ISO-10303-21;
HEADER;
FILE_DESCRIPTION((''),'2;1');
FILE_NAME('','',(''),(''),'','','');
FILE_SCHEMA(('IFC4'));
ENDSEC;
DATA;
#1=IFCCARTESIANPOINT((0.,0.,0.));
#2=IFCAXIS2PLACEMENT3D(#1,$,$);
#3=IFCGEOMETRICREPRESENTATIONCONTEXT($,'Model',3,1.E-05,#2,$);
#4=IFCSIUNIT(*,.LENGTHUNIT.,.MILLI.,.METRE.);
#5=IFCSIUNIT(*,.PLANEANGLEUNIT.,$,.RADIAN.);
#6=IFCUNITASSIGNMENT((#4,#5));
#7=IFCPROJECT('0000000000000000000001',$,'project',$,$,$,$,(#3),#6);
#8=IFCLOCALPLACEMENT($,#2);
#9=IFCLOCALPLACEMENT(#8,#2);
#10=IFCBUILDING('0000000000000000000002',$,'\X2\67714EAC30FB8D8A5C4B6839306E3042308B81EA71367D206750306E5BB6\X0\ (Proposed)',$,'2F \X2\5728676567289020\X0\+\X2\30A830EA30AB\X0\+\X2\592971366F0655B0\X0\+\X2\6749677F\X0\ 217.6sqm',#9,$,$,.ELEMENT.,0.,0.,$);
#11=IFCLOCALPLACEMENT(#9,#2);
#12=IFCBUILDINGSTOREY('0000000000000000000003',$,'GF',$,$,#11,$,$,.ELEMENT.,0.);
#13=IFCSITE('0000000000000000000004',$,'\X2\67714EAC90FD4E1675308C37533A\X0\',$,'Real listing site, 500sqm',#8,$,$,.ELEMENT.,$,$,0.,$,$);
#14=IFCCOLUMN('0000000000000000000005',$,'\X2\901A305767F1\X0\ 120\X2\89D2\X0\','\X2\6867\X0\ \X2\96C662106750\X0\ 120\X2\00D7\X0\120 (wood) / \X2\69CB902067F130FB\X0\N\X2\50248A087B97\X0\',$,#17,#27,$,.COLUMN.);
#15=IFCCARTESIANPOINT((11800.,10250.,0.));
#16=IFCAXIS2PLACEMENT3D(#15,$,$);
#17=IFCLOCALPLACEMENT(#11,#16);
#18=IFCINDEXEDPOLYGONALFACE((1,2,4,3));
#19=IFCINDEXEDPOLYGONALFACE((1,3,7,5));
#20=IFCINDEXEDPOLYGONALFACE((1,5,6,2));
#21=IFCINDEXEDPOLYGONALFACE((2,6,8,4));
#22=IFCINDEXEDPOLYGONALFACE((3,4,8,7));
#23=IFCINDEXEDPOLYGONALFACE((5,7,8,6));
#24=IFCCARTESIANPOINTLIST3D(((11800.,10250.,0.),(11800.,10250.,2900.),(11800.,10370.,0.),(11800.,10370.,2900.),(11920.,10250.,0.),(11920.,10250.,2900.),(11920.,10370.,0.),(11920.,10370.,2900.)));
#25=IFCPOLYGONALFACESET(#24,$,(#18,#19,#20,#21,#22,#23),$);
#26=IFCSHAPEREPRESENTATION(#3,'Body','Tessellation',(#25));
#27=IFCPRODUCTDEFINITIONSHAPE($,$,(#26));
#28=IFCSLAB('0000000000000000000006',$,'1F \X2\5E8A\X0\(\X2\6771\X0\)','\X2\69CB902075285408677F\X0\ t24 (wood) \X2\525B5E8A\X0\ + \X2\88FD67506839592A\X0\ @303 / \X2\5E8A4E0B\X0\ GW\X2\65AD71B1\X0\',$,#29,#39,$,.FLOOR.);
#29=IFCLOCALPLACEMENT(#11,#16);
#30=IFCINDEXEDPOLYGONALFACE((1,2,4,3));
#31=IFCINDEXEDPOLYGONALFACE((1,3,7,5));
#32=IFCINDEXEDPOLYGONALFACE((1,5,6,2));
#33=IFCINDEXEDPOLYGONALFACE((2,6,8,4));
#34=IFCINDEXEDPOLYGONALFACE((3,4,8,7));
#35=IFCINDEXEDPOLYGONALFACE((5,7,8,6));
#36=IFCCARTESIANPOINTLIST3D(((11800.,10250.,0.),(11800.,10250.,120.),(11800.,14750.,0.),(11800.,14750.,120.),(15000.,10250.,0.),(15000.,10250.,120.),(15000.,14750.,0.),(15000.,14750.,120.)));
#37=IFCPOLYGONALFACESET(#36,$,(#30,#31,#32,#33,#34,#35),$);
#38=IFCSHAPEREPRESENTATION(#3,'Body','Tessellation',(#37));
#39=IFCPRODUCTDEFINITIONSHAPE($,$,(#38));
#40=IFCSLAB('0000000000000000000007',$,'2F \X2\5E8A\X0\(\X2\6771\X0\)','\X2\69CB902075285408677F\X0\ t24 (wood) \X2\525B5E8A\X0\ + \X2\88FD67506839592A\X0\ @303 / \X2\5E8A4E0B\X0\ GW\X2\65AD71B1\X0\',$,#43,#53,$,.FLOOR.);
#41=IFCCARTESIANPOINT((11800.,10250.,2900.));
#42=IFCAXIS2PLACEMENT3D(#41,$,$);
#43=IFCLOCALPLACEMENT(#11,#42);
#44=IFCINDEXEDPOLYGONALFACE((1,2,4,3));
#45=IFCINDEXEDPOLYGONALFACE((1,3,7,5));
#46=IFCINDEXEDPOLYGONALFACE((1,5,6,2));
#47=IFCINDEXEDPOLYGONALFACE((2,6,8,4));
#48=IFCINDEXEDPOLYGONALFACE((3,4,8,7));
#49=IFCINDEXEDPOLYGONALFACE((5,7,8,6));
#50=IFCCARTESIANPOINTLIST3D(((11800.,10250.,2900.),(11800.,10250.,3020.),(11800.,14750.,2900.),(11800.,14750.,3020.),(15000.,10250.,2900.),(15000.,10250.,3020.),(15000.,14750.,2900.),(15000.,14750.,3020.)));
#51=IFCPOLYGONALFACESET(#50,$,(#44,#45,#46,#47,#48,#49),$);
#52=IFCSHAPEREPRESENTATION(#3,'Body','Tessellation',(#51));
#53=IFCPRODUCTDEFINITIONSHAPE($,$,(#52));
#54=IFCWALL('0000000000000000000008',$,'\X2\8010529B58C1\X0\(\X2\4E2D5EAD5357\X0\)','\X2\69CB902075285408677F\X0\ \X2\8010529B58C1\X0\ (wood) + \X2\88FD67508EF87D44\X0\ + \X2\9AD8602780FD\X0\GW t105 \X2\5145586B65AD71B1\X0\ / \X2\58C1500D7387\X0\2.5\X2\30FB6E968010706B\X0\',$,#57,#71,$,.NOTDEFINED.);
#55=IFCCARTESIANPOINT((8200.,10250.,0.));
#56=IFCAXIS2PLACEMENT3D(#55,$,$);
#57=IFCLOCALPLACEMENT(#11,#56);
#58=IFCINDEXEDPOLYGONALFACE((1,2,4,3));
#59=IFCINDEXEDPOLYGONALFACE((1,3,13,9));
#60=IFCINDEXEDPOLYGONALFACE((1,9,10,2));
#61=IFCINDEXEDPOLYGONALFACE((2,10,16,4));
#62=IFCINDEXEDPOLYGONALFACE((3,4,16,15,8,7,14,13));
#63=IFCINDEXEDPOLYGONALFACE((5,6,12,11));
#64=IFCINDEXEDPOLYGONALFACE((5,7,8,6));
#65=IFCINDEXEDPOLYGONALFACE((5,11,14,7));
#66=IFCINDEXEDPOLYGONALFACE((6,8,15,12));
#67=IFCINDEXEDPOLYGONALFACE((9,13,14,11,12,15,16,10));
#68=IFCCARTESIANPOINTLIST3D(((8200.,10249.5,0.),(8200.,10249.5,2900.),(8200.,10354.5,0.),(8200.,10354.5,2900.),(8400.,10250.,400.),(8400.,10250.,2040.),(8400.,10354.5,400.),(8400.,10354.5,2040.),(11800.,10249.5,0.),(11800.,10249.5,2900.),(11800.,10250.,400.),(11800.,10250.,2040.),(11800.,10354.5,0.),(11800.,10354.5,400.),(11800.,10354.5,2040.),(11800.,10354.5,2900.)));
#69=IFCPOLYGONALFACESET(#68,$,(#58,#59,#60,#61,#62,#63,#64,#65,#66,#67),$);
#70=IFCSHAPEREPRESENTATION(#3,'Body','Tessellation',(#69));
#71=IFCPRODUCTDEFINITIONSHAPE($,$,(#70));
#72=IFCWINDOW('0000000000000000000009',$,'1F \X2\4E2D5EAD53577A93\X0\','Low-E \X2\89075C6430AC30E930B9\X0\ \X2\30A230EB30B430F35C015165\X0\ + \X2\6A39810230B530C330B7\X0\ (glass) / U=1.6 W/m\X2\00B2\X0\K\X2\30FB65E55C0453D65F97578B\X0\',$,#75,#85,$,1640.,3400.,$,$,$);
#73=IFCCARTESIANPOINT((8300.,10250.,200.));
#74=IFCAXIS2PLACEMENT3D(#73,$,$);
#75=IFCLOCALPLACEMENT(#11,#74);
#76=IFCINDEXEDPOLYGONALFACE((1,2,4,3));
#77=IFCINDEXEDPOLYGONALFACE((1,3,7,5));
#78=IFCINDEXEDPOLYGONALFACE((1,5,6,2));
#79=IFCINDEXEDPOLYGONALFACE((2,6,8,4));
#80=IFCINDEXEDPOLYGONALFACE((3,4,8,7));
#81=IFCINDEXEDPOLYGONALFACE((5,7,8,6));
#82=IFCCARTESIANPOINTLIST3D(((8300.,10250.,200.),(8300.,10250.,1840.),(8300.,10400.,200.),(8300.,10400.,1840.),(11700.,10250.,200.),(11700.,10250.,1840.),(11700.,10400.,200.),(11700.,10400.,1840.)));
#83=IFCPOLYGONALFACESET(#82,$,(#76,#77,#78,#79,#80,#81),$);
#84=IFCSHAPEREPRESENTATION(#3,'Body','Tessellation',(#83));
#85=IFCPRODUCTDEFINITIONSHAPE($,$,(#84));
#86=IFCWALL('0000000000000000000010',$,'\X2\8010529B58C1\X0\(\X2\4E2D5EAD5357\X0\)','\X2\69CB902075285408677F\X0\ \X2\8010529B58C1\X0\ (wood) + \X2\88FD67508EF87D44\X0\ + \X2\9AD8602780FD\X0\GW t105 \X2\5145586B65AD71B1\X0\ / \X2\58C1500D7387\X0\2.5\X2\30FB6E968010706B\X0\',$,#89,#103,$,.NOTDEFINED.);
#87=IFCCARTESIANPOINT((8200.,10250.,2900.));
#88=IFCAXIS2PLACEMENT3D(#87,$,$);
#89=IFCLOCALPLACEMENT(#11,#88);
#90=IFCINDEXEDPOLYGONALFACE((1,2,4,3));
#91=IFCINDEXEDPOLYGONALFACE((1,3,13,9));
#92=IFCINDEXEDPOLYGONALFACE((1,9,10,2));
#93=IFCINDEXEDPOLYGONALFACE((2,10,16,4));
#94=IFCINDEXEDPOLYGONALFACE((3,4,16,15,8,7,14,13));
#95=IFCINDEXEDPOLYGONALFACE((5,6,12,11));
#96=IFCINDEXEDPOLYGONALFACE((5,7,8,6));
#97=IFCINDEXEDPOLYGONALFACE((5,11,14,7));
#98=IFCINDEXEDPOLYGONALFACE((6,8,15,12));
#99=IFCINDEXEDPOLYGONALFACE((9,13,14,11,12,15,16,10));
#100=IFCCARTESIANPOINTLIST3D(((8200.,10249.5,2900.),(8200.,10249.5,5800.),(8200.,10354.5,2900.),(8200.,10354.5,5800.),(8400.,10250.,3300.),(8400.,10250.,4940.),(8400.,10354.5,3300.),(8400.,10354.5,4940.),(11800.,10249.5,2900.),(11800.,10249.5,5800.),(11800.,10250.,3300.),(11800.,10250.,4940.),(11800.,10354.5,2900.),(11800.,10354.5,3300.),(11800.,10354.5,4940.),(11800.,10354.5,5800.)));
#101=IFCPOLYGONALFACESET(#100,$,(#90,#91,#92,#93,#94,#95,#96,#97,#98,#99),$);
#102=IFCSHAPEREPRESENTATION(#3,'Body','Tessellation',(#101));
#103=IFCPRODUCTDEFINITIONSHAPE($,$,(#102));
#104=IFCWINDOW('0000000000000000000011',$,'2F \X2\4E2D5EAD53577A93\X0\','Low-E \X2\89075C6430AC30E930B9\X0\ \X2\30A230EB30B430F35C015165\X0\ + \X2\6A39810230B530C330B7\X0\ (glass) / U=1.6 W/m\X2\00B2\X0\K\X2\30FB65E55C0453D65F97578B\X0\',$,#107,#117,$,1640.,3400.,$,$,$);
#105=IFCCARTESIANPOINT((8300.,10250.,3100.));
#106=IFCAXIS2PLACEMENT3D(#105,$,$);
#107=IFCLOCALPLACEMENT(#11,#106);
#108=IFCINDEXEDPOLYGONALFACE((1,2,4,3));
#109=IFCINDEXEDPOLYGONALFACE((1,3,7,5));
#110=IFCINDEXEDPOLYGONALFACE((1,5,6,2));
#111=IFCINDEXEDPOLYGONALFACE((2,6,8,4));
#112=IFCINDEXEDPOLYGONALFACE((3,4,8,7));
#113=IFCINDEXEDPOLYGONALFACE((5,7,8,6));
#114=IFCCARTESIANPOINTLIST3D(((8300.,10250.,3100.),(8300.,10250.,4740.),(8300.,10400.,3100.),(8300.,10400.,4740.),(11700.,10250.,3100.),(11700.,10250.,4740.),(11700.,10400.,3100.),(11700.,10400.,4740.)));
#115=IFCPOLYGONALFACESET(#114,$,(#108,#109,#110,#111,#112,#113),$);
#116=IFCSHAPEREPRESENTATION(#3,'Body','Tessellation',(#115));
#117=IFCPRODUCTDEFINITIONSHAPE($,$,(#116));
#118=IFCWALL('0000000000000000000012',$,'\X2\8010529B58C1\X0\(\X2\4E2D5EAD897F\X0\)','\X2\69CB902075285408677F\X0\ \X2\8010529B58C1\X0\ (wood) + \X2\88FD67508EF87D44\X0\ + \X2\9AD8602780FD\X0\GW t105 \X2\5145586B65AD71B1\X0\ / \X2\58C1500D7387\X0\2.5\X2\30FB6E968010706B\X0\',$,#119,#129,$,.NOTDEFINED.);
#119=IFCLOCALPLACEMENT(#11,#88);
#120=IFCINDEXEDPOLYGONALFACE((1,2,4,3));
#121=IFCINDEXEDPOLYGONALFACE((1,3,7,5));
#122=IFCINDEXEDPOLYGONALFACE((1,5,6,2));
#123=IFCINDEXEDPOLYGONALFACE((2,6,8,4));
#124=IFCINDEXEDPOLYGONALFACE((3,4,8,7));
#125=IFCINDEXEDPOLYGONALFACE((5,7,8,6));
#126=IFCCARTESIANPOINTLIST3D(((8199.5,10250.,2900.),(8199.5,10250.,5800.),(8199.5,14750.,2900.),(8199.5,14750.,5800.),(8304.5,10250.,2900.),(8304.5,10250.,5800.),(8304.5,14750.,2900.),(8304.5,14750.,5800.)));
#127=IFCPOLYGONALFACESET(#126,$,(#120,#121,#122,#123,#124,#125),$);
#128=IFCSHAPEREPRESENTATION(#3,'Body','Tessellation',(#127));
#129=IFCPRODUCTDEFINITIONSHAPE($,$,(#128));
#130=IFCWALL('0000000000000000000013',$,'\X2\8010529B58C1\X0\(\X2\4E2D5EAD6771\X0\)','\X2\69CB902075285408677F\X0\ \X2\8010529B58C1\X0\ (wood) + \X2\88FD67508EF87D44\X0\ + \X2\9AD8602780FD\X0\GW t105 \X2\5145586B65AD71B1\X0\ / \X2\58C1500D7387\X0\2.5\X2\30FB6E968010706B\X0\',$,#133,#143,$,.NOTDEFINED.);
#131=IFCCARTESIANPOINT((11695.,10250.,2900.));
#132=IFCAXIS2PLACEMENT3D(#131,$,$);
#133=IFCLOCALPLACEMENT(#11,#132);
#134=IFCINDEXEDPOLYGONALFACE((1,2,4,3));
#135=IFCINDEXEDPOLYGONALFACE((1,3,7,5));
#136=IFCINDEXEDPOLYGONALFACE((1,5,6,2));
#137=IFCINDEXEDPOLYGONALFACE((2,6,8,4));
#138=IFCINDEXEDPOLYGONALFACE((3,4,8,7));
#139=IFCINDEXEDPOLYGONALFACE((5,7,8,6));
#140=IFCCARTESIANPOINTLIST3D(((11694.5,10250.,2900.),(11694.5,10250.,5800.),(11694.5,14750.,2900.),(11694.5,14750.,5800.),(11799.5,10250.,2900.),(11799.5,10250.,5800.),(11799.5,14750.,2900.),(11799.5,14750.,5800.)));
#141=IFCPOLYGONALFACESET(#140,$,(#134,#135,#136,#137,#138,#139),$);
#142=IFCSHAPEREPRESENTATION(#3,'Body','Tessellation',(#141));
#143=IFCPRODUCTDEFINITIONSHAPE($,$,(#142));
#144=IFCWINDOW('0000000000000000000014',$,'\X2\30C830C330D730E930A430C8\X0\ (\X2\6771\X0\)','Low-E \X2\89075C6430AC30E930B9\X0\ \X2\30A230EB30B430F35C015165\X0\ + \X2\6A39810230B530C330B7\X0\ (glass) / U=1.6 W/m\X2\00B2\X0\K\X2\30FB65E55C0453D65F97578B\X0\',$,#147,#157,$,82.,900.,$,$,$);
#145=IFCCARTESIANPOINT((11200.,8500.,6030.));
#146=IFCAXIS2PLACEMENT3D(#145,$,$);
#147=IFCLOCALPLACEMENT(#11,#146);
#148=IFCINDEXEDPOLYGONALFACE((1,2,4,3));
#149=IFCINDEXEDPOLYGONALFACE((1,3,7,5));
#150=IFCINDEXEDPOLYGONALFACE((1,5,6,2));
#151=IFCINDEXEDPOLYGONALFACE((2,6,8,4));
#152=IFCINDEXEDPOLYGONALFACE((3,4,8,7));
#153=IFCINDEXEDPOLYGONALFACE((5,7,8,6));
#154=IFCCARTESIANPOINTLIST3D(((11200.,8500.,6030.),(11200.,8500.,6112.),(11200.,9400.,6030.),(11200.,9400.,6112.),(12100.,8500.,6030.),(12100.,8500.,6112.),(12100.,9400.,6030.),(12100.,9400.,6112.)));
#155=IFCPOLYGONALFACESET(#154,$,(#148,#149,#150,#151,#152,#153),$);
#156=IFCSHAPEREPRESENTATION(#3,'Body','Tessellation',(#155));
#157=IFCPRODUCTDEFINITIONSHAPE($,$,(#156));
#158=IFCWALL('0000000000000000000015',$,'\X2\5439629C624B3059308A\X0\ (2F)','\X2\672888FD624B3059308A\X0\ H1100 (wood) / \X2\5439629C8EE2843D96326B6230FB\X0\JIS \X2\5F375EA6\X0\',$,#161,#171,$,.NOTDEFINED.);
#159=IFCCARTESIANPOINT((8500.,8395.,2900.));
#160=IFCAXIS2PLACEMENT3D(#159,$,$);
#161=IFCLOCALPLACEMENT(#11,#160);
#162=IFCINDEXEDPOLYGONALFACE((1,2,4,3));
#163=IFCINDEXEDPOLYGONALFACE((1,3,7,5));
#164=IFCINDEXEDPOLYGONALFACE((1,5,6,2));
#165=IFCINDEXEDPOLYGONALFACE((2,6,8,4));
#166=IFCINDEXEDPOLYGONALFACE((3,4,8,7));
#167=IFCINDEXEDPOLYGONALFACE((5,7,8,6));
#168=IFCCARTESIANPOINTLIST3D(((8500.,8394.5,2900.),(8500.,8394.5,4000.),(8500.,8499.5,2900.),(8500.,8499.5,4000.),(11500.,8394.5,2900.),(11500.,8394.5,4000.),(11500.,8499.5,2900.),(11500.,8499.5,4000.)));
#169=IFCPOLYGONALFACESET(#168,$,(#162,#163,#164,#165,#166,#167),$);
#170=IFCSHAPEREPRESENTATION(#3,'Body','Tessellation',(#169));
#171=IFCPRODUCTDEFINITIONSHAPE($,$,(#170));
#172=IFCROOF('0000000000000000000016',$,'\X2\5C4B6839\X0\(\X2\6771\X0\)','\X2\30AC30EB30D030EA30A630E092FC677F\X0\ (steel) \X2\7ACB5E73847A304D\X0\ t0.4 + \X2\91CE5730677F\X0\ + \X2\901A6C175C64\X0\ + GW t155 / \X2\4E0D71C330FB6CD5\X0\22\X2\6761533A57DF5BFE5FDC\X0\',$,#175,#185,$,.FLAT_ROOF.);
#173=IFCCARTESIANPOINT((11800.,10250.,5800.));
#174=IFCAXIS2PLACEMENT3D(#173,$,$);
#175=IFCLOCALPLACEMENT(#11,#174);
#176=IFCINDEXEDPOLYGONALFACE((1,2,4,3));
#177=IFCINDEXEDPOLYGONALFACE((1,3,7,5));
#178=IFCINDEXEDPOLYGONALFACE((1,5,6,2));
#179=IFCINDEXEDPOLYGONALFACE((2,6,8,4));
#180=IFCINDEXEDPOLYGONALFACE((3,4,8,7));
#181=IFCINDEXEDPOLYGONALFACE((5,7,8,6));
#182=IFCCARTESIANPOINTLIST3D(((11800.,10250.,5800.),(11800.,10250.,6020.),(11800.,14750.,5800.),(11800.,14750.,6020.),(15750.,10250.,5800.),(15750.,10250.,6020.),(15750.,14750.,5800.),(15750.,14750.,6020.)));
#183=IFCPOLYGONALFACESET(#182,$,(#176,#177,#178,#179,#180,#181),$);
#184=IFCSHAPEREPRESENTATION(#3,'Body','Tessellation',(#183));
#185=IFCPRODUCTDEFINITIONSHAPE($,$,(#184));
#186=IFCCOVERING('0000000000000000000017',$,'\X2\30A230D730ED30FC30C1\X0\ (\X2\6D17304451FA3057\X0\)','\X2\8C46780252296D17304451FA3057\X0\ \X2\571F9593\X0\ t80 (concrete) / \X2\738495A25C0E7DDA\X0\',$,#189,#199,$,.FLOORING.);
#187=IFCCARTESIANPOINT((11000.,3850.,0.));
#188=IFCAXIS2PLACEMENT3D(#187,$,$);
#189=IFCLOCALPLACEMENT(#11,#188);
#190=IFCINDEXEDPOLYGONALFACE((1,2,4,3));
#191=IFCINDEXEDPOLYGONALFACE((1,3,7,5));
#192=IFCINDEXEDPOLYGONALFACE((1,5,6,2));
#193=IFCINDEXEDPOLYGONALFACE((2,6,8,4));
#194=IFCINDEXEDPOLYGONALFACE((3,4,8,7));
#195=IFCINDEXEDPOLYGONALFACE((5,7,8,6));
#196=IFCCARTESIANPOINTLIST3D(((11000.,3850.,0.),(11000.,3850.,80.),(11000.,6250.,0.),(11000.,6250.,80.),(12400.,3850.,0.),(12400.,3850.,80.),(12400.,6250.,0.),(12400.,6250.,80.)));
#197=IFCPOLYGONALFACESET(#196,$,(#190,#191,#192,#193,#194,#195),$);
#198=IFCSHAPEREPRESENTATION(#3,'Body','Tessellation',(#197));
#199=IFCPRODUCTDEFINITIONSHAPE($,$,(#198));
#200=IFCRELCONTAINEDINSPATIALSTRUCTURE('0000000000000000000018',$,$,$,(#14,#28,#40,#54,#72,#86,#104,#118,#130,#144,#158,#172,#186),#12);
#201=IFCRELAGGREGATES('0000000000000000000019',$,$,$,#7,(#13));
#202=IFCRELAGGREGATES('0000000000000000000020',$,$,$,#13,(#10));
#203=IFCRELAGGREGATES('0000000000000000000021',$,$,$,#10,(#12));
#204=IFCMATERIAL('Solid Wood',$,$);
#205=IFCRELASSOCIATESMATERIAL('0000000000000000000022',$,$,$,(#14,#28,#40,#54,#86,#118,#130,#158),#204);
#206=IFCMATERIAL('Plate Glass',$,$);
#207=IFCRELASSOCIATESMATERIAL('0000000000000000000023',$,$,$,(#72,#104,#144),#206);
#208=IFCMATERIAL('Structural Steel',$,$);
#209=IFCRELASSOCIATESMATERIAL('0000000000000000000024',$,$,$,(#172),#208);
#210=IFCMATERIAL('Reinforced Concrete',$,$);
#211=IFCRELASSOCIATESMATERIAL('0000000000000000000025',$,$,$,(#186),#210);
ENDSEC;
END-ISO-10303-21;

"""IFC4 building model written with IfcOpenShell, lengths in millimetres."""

from ifc_helpers import new_model, si_unit, frame, frame_2d, origin, place, context, project, spatial, rectangle, extrude, material, element, fill, save


model = new_model("IFC4")

# Units and contexts
model_context = context("Model", 3, precision=1e-05, world=origin())
ifc_project = project(units=[si_unit("LENGTHUNIT", "METRE", prefix="MILLI"), si_unit("PLANEANGLEUNIT", "RADIAN")], contexts=[model_context])

# Site, building, storey
site_placement = place(None, origin())
site = spatial("IfcSite", under=ifc_project, at=site_placement, Name="東京都世田谷区", ObjectType="Real listing site, 500sqm", CompositionType="ELEMENT", RefElevation=0.0)
building_placement = place(site_placement, origin())
building = spatial("IfcBuilding", under=site, at=building_placement, Name="東京・越屋根のある自然素材の家 (Proposed)", ObjectType="2F 在来木造+エリカ+天然漆喰+杉板 217.6sqm", CompositionType="ELEMENT", ElevationOfRefHeight=0.0, ElevationOfTerrain=0.0)
storey_placement = place(building_placement, origin())
storey = spatial("IfcBuildingStorey", under=building, at=storey_placement, Name="GF", CompositionType="ELEMENT", Elevation=0.0)

# Column
ifc_material_1 = material(Name="Solid Wood")
column_1_placement = place(storey_placement, frame((11800.0, 10250.0, 0.0)))
element("IfcColumn", 1, at=column_1_placement, inside=storey, material=ifc_material_1, Name="通し柱 120角", Description="桧 集成材 120×120 (wood) / 構造柱・N値計算", PredefinedType="COLUMN", context=model_context, shape_type="SweptSolid", body=[
    extrude(rectangle(XDim=120.0, YDim=120.0, at=frame_2d((60.0, 60.0))), frame((11800.0, 10250.0, 0.0)), (0.0, 0.0, 1.0), 2900.0),
])

# Slabs
slab_1_placement = place(storey_placement, frame((11800.0, 10250.0, 0.0)))
element("IfcSlab", 2, at=slab_1_placement, inside=storey, material=ifc_material_1, Name="1F 床(東)", Description="構造用合板 t24 (wood) 剛床 + 製材根太 @303 / 床下 GW断熱", PredefinedType="FLOOR", context=model_context, shape_type="SweptSolid", body=[
    extrude(rectangle(XDim=3200.0, YDim=4500.0, at=frame_2d((1600.0, 2250.0))), frame((11800.0, 10250.0, 0.0)), (0.0, 0.0, 1.0), 120.0),
])
slab_2_placement = place(storey_placement, frame((11800.0, 10250.0, 2900.0)))
element("IfcSlab", 3, at=slab_2_placement, inside=storey, material=ifc_material_1, Name="2F 床(東)", Description="構造用合板 t24 (wood) 剛床 + 製材根太 @303 / 床下 GW断熱", PredefinedType="FLOOR", context=model_context, shape_type="SweptSolid", body=[
    extrude(rectangle(XDim=3200.0, YDim=4500.0, at=frame_2d((1600.0, 2250.0))), frame((11800.0, 10250.0, 2900.0)), (0.0, 0.0, 1.0), 120.0),
])

# Wall, opening, window
wall_1_placement = place(storey_placement, frame((8200.0, 10250.0, 0.0)))
wall_1 = element("IfcWall", 4, at=wall_1_placement, inside=storey, material=ifc_material_1, Name="耐力壁(中庭南)", Description="構造用合板 耐力壁 (wood) + 製材軸組 + 高性能GW t105 充填断熱 / 壁倍率2.5・準耐火", PredefinedType="NOTDEFINED", context=model_context, shape_type="SweptSolid", body=[
    extrude(rectangle(XDim=3600.0, YDim=105.0, at=frame_2d((1800.0, 52.0))), frame((8200.0, 10250.0, 0.0)), (0.0, 0.0, 1.0), 2900.0),
])
opening_1_placement = place(storey_placement, frame((8300.0, 10250.0, 200.0)))
opening_1 = element("IfcOpeningElement", 5, at=opening_1_placement, cuts=wall_1, PredefinedType="NOTDEFINED", context=model_context, shape_type="SweptSolid", body=[
    extrude(rectangle(XDim=3400.0, YDim=150.0, at=frame_2d((1700.0, 75.0))), frame((8300.0, 10250.0, 200.0)), (0.0, 0.0, 1.0), 1640.0),
])
ifc_material_2 = material(Name="Plate Glass")
window_1_placement = place(storey_placement, frame((8300.0, 10250.0, 200.0)))
window_1 = element("IfcWindow", 6, at=window_1_placement, inside=storey, material=ifc_material_2, Name="1F 中庭南窓", Description="Low-E 複層ガラス アルゴン封入 + 樹脂サッシ (glass) / U=1.6 W/m²K・日射取得型", OverallHeight=1640.0, OverallWidth=3400.0, context=model_context, shape_type="SweptSolid", body=[
    extrude(rectangle(XDim=3400.0, YDim=150.0, at=frame_2d((1700.0, 75.0))), frame((8300.0, 10250.0, 200.0)), (0.0, 0.0, 1.0), 1640.0),
])
fill(opening_1, window_1)

# Wall, opening, window
wall_2_placement = place(storey_placement, frame((8200.0, 10250.0, 2900.0)))
wall_2 = element("IfcWall", 7, at=wall_2_placement, inside=storey, material=ifc_material_1, Name="耐力壁(中庭南)", Description="構造用合板 耐力壁 (wood) + 製材軸組 + 高性能GW t105 充填断熱 / 壁倍率2.5・準耐火", PredefinedType="NOTDEFINED", context=model_context, shape_type="SweptSolid", body=[
    extrude(rectangle(XDim=3600.0, YDim=105.0, at=frame_2d((1800.0, 52.0))), frame((8200.0, 10250.0, 2900.0)), (0.0, 0.0, 1.0), 2900.0),
])
opening_2_placement = place(storey_placement, frame((8300.0, 10250.0, 3100.0)))
opening_2 = element("IfcOpeningElement", 8, at=opening_2_placement, cuts=wall_2, PredefinedType="NOTDEFINED", context=model_context, shape_type="SweptSolid", body=[
    extrude(rectangle(XDim=3400.0, YDim=150.0, at=frame_2d((1700.0, 75.0))), frame((8300.0, 10250.0, 3100.0)), (0.0, 0.0, 1.0), 1640.0),
])
window_2_placement = place(storey_placement, frame((8300.0, 10250.0, 3100.0)))
window_2 = element("IfcWindow", 9, at=window_2_placement, inside=storey, material=ifc_material_2, Name="2F 中庭南窓", Description="Low-E 複層ガラス アルゴン封入 + 樹脂サッシ (glass) / U=1.6 W/m²K・日射取得型", OverallHeight=1640.0, OverallWidth=3400.0, context=model_context, shape_type="SweptSolid", body=[
    extrude(rectangle(XDim=3400.0, YDim=150.0, at=frame_2d((1700.0, 75.0))), frame((8300.0, 10250.0, 3100.0)), (0.0, 0.0, 1.0), 1640.0),
])
fill(opening_2, window_2)

# Walls
wall_3_placement = place(storey_placement, frame((8200.0, 10250.0, 2900.0)))
element("IfcWall", 10, at=wall_3_placement, inside=storey, material=ifc_material_1, Name="耐力壁(中庭西)", Description="構造用合板 耐力壁 (wood) + 製材軸組 + 高性能GW t105 充填断熱 / 壁倍率2.5・準耐火", PredefinedType="NOTDEFINED", context=model_context, shape_type="SweptSolid", body=[
    extrude(rectangle(XDim=105.0, YDim=4500.0, at=frame_2d((52.0, 2250.0))), frame((8200.0, 10250.0, 2900.0)), (0.0, 0.0, 1.0), 2900.0),
])
wall_4_placement = place(storey_placement, frame((11695.0, 10250.0, 2900.0)))
element("IfcWall", 11, at=wall_4_placement, inside=storey, material=ifc_material_1, Name="耐力壁(中庭東)", Description="構造用合板 耐力壁 (wood) + 製材軸組 + 高性能GW t105 充填断熱 / 壁倍率2.5・準耐火", PredefinedType="NOTDEFINED", context=model_context, shape_type="SweptSolid", body=[
    extrude(rectangle(XDim=105.0, YDim=4500.0, at=frame_2d((52.0, 2250.0))), frame((11695.0, 10250.0, 2900.0)), (0.0, 0.0, 1.0), 2900.0),
])

# Window
window_3_placement = place(storey_placement, frame((11200.0, 8500.0, 6030.0)))
element("IfcWindow", 12, at=window_3_placement, inside=storey, material=ifc_material_2, Name="トップライト (東)", Description="Low-E 複層ガラス アルゴン封入 + 樹脂サッシ (glass) / U=1.6 W/m²K・日射取得型", OverallHeight=82.0, OverallWidth=900.0, context=model_context, shape_type="SweptSolid", body=[
    extrude(rectangle(XDim=900.0, YDim=900.0, at=frame_2d((450.0, 450.0))), frame((11200.0, 8500.0, 6030.0)), (0.0, 0.0, 1.0), 82.0),
])

# Wall
wall_5_placement = place(storey_placement, frame((8500.0, 8395.0, 2900.0)))
element("IfcWall", 13, at=wall_5_placement, inside=storey, material=ifc_material_1, Name="吹抜手すり (2F)", Description="木製手すり H1100 (wood) / 吹抜転落防止・JIS 強度", PredefinedType="NOTDEFINED", context=model_context, shape_type="SweptSolid", body=[
    extrude(rectangle(XDim=3000.0, YDim=105.0, at=frame_2d((1500.0, 52.0))), frame((8500.0, 8395.0, 2900.0)), (0.0, 0.0, 1.0), 1100.0),
])

# Roof
ifc_material_3 = material(Name="Structural Steel")
for number, where, name in (
    (14, (11800.0, 10250.0, 5800.0), "屋根(東)"),
):
    element("IfcRoof", number, at=place(storey_placement, frame(where)), inside=storey, material=ifc_material_3, Name=name, Description="ガルバリウム鋼板 (steel) 立平葺き t0.4 + 野地板 + 通気層 + GW t155 / 不燃・法22条区域対応", PredefinedType="FLAT_ROOF", context=model_context, shape_type="SweptSolid", body=[
        extrude(rectangle(XDim=3950.0, YDim=4500.0, at=frame_2d((1975.0, 2250.0))), frame((11800.0, 10250.0, 5800.0)), (0.0, 0.0, 1.0), 220.0),
    ])

# Covering
ifc_material_4 = material(Name="Reinforced Concrete")
covering_placement = place(storey_placement, frame((11000.0, 3850.0, 0.0)))
element("IfcCovering", 15, at=covering_placement, inside=storey, material=ifc_material_4, Name="アプローチ (洗い出し)", Description="豆砂利洗い出し 土間 t80 (concrete) / 玄関導線", PredefinedType="FLOORING", context=model_context, shape_type="SweptSolid", body=[
    extrude(rectangle(XDim=1400.0, YDim=2400.0, at=frame_2d((700.0, 1200.0))), frame((11000.0, 3850.0, 0.0)), (0.0, 0.0, 1.0), 80.0),
])

save(model, "model.ifc")
